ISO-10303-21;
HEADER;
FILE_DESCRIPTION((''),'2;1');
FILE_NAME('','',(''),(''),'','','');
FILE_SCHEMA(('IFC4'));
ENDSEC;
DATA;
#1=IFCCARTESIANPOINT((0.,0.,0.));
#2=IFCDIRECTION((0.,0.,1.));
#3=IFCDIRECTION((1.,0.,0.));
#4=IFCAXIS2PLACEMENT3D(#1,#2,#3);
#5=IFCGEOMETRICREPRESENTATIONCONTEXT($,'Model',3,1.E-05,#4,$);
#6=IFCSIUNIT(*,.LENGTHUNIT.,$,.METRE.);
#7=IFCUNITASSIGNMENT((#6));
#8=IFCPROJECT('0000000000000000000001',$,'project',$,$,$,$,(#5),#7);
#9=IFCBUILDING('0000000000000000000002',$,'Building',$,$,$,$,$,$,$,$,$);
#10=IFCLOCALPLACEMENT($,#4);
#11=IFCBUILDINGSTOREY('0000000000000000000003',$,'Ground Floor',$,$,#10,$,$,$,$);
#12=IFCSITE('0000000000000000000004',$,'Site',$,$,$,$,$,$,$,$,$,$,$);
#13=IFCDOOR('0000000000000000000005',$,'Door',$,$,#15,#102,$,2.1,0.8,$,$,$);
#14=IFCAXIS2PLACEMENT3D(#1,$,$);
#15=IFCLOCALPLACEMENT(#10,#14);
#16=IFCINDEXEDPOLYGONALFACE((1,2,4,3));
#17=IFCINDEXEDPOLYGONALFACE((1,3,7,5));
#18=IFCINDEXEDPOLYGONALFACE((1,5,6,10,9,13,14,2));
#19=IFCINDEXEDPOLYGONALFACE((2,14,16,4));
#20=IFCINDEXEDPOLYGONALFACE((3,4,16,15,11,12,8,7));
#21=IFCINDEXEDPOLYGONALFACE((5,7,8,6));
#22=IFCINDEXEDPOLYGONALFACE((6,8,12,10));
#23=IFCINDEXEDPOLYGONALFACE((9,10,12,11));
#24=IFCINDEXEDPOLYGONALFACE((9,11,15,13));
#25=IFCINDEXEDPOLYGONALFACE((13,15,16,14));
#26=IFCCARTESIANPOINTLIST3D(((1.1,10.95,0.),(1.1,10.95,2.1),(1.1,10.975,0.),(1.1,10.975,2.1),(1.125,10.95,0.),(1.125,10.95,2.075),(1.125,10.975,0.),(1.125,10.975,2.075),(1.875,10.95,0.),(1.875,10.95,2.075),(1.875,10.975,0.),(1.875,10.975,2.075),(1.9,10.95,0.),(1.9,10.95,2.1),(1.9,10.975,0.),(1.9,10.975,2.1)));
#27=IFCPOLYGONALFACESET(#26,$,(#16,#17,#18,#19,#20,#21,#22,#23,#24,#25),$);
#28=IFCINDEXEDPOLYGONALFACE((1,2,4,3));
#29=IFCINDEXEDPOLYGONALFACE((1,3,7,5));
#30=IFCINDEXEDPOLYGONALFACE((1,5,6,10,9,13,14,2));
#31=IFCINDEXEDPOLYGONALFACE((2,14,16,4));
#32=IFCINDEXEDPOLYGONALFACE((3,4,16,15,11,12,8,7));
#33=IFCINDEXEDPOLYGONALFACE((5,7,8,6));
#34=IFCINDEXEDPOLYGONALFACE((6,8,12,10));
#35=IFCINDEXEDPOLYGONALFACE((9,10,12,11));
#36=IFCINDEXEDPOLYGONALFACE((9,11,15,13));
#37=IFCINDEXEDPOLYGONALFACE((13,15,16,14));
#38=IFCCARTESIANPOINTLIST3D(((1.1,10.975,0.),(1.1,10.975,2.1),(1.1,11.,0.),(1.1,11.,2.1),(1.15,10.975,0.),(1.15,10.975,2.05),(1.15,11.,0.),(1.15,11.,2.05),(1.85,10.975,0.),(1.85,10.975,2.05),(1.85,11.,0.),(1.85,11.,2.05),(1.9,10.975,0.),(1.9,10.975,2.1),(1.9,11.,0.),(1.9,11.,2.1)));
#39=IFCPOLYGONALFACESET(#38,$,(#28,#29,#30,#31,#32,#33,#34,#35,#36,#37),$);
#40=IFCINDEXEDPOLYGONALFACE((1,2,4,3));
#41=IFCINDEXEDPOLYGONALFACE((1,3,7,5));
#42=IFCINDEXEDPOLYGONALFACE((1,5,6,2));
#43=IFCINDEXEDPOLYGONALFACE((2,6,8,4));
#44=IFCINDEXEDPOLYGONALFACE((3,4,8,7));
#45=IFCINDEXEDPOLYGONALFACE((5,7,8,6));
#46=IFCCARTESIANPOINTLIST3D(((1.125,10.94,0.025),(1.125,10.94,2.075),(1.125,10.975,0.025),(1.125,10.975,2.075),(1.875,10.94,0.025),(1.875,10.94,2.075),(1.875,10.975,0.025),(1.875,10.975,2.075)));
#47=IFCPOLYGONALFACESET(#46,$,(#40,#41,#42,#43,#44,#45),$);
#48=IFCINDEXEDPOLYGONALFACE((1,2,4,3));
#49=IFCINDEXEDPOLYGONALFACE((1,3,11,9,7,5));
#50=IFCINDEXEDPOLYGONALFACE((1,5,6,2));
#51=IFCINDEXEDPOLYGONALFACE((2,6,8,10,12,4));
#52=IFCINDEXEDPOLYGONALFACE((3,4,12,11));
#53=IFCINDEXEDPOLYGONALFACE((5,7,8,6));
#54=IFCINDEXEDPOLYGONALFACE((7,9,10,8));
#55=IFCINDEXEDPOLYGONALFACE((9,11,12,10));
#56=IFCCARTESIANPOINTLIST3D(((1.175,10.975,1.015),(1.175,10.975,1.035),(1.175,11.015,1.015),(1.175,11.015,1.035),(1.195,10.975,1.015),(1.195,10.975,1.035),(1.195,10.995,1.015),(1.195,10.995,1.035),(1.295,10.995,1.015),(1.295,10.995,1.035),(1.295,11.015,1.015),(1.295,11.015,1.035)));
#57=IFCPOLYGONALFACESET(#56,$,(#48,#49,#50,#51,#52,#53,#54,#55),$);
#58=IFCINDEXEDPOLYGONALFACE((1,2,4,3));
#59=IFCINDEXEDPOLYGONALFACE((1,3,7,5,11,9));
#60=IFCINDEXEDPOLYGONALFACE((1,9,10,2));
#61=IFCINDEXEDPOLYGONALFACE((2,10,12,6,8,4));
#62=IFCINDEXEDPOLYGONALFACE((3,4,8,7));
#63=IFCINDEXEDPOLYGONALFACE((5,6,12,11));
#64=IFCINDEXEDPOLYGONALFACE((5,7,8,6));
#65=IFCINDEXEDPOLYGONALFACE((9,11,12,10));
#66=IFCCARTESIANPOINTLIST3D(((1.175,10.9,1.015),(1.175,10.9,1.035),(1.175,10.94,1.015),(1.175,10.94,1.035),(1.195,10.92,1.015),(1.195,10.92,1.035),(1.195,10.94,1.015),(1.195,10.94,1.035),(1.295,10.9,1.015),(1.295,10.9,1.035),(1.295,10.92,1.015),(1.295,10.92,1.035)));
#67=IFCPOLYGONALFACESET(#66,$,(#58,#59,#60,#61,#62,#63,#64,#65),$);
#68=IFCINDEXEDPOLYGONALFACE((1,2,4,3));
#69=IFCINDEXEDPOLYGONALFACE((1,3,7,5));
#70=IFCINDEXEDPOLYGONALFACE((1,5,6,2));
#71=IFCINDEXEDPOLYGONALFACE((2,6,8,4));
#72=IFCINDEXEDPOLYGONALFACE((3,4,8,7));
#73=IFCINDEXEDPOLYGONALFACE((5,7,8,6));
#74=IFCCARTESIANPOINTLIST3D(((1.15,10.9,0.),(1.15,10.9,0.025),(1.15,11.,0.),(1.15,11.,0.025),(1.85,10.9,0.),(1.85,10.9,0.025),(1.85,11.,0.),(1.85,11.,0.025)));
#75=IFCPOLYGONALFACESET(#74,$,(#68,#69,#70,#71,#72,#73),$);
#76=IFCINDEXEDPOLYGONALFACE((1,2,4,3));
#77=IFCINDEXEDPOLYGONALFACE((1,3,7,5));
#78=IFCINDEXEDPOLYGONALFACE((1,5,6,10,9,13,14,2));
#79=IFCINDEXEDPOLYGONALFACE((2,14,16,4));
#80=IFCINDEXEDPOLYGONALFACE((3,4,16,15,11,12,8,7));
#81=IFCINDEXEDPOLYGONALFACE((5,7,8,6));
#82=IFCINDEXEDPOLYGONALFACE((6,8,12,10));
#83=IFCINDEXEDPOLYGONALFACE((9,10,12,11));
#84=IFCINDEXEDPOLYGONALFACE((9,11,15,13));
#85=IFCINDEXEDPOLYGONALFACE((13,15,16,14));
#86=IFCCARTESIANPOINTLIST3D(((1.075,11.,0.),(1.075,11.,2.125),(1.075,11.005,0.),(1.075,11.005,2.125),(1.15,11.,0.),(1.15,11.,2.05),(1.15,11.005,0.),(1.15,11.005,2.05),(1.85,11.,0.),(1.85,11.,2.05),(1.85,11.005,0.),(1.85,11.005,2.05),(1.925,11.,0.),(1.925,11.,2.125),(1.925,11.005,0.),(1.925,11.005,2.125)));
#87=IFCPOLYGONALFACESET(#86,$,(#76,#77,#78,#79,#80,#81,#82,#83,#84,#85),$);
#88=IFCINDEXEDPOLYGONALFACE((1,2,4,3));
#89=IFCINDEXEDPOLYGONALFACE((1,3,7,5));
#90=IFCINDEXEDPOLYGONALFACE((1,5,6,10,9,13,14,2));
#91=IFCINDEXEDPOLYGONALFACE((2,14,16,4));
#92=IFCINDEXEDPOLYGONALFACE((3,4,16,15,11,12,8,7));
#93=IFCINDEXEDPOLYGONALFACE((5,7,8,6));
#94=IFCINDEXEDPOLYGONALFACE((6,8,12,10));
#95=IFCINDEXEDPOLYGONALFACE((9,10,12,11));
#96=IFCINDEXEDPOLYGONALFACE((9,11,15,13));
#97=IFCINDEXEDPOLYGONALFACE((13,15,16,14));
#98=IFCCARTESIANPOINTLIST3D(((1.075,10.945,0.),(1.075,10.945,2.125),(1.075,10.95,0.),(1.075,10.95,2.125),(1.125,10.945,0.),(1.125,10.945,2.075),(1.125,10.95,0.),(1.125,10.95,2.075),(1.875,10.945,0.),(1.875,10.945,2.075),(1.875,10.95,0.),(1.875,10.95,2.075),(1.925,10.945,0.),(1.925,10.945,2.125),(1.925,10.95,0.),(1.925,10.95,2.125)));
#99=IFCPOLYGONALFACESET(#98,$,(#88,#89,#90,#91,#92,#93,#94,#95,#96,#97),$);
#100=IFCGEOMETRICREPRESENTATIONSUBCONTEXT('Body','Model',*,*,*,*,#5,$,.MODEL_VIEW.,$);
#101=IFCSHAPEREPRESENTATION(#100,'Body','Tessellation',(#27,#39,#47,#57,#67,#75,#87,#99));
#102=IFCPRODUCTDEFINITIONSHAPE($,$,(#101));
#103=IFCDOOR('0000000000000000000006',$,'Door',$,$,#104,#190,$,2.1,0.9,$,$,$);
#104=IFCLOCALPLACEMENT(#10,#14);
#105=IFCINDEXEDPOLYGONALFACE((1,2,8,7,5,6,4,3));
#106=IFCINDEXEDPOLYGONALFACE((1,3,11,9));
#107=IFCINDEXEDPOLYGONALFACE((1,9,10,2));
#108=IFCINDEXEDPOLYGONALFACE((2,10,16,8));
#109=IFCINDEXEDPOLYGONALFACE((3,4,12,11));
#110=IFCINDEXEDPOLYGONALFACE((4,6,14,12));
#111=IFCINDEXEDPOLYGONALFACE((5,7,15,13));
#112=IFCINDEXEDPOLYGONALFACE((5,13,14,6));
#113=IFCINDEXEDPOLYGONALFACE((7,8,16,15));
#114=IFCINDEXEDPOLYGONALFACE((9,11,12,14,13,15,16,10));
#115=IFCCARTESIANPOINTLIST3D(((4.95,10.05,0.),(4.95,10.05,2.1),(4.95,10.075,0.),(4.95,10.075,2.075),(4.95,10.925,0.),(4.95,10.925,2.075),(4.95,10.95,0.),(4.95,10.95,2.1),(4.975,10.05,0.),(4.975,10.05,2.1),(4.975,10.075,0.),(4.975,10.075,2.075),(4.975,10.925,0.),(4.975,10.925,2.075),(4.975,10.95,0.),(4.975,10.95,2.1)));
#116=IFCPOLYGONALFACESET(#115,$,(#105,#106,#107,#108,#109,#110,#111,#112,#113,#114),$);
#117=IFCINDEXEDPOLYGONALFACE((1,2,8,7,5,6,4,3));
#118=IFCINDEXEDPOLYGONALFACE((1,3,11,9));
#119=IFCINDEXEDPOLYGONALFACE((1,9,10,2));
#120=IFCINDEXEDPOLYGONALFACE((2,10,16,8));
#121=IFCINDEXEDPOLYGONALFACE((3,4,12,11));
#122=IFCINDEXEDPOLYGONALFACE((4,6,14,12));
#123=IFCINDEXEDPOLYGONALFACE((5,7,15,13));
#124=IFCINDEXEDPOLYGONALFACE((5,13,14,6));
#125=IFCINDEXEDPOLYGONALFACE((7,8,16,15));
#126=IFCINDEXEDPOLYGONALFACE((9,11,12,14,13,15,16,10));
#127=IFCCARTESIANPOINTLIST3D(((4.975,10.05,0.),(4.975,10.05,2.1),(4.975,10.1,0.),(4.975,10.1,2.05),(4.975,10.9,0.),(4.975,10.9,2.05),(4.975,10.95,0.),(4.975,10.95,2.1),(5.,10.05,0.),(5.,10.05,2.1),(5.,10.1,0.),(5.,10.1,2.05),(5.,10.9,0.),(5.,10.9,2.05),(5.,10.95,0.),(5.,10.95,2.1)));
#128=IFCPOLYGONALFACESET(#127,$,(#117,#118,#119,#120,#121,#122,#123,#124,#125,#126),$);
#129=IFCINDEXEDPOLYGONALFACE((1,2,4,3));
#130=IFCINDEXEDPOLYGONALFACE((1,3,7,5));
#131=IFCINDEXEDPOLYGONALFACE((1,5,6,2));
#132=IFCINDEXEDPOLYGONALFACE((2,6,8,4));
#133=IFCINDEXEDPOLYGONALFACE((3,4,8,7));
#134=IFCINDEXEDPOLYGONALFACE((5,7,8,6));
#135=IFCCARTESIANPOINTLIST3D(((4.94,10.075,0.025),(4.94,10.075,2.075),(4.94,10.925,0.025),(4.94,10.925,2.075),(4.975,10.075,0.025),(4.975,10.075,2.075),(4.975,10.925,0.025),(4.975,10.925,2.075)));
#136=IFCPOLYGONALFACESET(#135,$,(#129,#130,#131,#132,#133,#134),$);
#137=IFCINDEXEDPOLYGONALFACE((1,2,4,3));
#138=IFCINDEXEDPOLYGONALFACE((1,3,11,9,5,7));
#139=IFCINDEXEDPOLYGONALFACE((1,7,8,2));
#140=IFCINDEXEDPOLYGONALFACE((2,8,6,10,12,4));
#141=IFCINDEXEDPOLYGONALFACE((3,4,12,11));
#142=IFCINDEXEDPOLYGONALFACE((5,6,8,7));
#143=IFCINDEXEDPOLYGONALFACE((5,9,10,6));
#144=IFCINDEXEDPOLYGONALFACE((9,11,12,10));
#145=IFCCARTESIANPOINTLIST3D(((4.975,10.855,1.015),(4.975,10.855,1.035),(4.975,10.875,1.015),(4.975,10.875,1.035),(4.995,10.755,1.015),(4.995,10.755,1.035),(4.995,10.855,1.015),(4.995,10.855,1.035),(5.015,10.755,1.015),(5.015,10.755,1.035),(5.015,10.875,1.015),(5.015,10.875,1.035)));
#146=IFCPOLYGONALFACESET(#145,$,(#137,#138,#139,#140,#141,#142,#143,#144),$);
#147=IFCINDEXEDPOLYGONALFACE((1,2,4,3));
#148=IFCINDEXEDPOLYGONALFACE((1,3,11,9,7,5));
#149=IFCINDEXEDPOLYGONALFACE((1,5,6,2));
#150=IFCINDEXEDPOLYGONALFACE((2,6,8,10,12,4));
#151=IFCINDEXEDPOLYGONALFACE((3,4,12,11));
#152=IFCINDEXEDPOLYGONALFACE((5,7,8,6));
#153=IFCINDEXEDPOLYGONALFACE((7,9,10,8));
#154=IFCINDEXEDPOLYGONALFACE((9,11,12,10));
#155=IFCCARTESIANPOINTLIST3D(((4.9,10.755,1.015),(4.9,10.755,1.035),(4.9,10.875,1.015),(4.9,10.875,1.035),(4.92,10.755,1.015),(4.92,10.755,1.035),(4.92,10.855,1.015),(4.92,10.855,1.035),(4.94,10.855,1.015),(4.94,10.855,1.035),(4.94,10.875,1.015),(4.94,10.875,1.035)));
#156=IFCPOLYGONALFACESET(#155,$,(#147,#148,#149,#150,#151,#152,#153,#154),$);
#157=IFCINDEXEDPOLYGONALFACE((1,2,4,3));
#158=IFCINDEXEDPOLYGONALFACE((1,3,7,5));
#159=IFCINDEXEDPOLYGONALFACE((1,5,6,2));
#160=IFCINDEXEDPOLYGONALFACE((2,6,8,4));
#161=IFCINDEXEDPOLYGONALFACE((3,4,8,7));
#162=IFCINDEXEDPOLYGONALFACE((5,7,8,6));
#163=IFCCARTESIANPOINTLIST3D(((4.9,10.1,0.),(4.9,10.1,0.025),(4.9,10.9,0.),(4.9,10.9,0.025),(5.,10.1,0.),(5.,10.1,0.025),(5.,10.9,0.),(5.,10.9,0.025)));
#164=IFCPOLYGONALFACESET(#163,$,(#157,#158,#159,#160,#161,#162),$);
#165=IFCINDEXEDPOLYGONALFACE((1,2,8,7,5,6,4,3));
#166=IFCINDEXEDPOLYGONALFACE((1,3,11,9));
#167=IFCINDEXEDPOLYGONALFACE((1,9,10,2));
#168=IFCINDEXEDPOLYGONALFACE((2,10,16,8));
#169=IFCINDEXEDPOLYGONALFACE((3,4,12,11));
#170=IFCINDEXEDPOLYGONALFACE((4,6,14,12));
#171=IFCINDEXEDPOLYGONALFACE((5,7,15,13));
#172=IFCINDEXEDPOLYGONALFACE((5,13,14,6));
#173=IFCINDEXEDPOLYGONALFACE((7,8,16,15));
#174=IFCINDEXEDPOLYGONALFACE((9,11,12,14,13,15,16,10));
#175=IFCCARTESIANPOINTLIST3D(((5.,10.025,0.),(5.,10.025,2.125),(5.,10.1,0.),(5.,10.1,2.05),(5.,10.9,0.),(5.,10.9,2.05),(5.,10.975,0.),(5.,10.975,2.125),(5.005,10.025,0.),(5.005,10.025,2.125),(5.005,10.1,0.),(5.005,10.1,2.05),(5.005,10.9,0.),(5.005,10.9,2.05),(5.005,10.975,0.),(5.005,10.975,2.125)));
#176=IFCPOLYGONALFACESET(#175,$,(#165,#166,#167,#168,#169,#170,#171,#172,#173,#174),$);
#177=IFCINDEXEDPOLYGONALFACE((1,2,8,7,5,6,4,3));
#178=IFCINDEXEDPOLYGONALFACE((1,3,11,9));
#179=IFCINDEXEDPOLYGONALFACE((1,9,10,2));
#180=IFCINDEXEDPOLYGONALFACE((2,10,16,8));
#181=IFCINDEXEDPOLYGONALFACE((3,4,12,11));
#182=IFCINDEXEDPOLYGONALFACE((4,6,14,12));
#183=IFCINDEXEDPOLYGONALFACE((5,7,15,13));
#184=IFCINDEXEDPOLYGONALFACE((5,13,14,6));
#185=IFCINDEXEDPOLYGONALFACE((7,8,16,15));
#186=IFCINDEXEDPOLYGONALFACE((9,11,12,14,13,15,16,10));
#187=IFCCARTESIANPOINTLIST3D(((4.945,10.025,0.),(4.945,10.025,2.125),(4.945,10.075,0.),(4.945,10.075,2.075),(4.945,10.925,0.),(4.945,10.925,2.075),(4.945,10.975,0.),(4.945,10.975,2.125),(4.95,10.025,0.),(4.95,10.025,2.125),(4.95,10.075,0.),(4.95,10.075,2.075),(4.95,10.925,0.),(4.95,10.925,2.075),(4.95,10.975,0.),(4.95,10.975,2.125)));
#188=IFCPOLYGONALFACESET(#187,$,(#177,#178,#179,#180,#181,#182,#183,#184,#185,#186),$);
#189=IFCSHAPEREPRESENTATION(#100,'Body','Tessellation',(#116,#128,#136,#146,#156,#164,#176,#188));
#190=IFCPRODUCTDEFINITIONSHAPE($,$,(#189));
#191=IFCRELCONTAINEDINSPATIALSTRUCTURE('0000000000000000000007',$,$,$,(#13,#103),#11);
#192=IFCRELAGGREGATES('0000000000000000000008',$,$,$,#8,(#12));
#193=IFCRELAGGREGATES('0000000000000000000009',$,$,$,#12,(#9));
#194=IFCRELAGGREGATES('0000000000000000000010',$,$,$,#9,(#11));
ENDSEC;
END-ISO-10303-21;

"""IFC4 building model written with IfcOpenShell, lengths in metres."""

from ifc_helpers import new_model, si_unit, frame, origin_with_axes, place, context, subcontext, project, spatial, line, indexed_curve, outline, extrude, element, save


model = new_model("IFC4")

# Units and contexts
model_context = context("Model", 3, precision=1e-05, world=origin_with_axes())
body_context = subcontext(model_context, "Body", "Model", "MODEL_VIEW")
ifc_project = project(units=[si_unit("LENGTHUNIT", "METRE")], contexts=[model_context])

# Site, building, storey
site = spatial("IfcSite", under=ifc_project, Name="Site")
building = spatial("IfcBuilding", under=site, Name="Building")
storey_placement = place(None, origin_with_axes())
storey = spatial("IfcBuildingStorey", under=building, at=storey_placement, Name="Ground Floor")

# Doors
door_1_placement = place(storey_placement, frame((1.9, 11.0, 0.0), z_axis=(0.0, 0.0, 1.0), x_axis=(-1.0, 0.0, 0.0)))
element("IfcDoor", 1, at=door_1_placement, inside=storey, Name="Door", OverallHeight=2.1, OverallWidth=0.8, context=body_context, shape_type="SweptSolid", body=[
    extrude(outline(indexed_curve([(0.0, 0.0), (0.0, 2.1), (0.8, 2.1), (0.8, 0.0), (0.775, 0.0), (0.775, 2.075), (0.025, 2.075), (0.025, 0.0)], segments=[line(1, 2, 3, 4, 5, 6, 7, 8, 1)])), frame((0.0, 0.025, 0.0), z_axis=(0.0, -1.0, 0.0), x_axis=(1.0, 0.0, 0.0)), (0.0, 0.0, -1.0), 0.025),
    extrude(outline(indexed_curve([(0.0, 0.0), (0.0, 2.1), (0.8, 2.1), (0.8, 0.0), (0.75, 0.0), (0.75, 2.05), (0.05, 2.05), (0.05, 0.0)], segments=[line(1, 2, 3, 4, 5, 6, 7, 8, 1)])), frame((0.0, 0.0, 0.0), z_axis=(0.0, -1.0, 0.0), x_axis=(1.0, 0.0, 0.0)), (0.0, 0.0, -1.0), 0.025),
    extrude(outline(indexed_curve([(0.0, 0.0), (0.75, 0.0), (0.75, 0.035), (0.0, 0.035)], segments=[line(1, 2, 3, 4, 1)])), frame((0.025, 0.025, 0.025), z_axis=(0.0, 0.0, 1.0), x_axis=(1.0, 0.0, 0.0)), (0.0, 0.0, 1.0), 2.05),
    extrude(outline(indexed_curve([(0.0, 0.0), (0.0, -0.04), (-0.12, -0.04), (-0.12, -0.02), (-0.02, -0.02), (-0.02, 0.0)], segments=[line(1, 2, 3, 4, 5, 6, 1)])), frame((0.725, 0.025, 1.015), z_axis=(0.0, 0.0, 1.0), x_axis=(1.0, 0.0, 0.0)), (0.0, 0.0, 1.0), 0.02),
    extrude(outline(indexed_curve([(0.0, 0.0), (0.0, 0.04), (-0.12, 0.04), (-0.12, 0.02), (-0.02, 0.02), (-0.02, 0.0)], segments=[line(1, 2, 3, 4, 5, 6, 1)])), frame((0.725, 0.06, 1.015), z_axis=(0.0, 0.0, 1.0), x_axis=(1.0, 0.0, 0.0)), (0.0, 0.0, 1.0), 0.02),
    extrude(outline(indexed_curve([(0.0, 0.0), (0.7, 0.0), (0.7, 0.1), (0.0, 0.1)], segments=[line(1, 2, 3, 4, 1)])), frame((0.05, 0.0, 0.0), z_axis=(0.0, 0.0, 1.0), x_axis=(1.0, 0.0, 0.0)), (0.0, 0.0, 1.0), 0.025),
    extrude(outline(indexed_curve([(0.0, 0.0), (0.0, 2.125), (0.85, 2.125), (0.85, 0.0), (0.775, 0.0), (0.775, 2.05), (0.075, 2.05), (0.075, 0.0)], segments=[line(1, 2, 3, 4, 5, 6, 7, 8, 1)])), frame((-0.025, -0.005, 0.0), z_axis=(0.0, -1.0, 0.0), x_axis=(1.0, 0.0, 0.0)), (0.0, 0.0, -1.0), 0.005),
    extrude(outline(indexed_curve([(0.0, 0.0), (0.0, 2.125), (0.85, 2.125), (0.85, 0.0), (0.8, 0.0), (0.8, 2.075), (0.05, 2.075), (0.05, 0.0)], segments=[line(1, 2, 3, 4, 5, 6, 7, 8, 1)])), frame((-0.025, 0.05, 0.0), z_axis=(0.0, -1.0, 0.0), x_axis=(1.0, 0.0, 0.0)), (0.0, 0.0, -1.0), 0.005),
])
door_2_placement = place(storey_placement, frame((5.0, 10.05, 0.0), z_axis=(0.0, 0.0, 1.0), x_axis=(0.0, 1.0, 0.0)))
element("IfcDoor", 2, at=door_2_placement, inside=storey, Name="Door", OverallHeight=2.1, OverallWidth=0.9, context=body_context, shape_type="SweptSolid", body=[
    extrude(outline(indexed_curve([(0.0, 0.0), (0.0, 2.1), (0.9, 2.1), (0.9, 0.0), (0.875, 0.0), (0.875, 2.075), (0.025, 2.075), (0.025, 0.0)], segments=[line(1, 2, 3, 4, 5, 6, 7, 8, 1)])), frame((0.0, 0.025, 0.0), z_axis=(0.0, -1.0, 0.0), x_axis=(1.0, 0.0, 0.0)), (0.0, 0.0, -1.0), 0.025),
    extrude(outline(indexed_curve([(0.0, 0.0), (0.0, 2.1), (0.9, 2.1), (0.9, 0.0), (0.85, 0.0), (0.85, 2.05), (0.05, 2.05), (0.05, 0.0)], segments=[line(1, 2, 3, 4, 5, 6, 7, 8, 1)])), frame((0.0, 0.0, 0.0), z_axis=(0.0, -1.0, 0.0), x_axis=(1.0, 0.0, 0.0)), (0.0, 0.0, -1.0), 0.025),
    extrude(outline(indexed_curve([(0.0, 0.0), (0.85, 0.0), (0.85, 0.035), (0.0, 0.035)], segments=[line(1, 2, 3, 4, 1)])), frame((0.025, 0.025, 0.025), z_axis=(0.0, 0.0, 1.0), x_axis=(1.0, 0.0, 0.0)), (0.0, 0.0, 1.0), 2.05),
    extrude(outline(indexed_curve([(0.0, 0.0), (0.0, -0.04), (-0.12, -0.04), (-0.12, -0.02), (-0.02, -0.02), (-0.02, 0.0)], segments=[line(1, 2, 3, 4, 5, 6, 1)])), frame((0.825, 0.025, 1.015), z_axis=(0.0, 0.0, 1.0), x_axis=(1.0, 0.0, 0.0)), (0.0, 0.0, 1.0), 0.02),
    extrude(outline(indexed_curve([(0.0, 0.0), (0.0, 0.04), (-0.12, 0.04), (-0.12, 0.02), (-0.02, 0.02), (-0.02, 0.0)], segments=[line(1, 2, 3, 4, 5, 6, 1)])), frame((0.825, 0.06, 1.015), z_axis=(0.0, 0.0, 1.0), x_axis=(1.0, 0.0, 0.0)), (0.0, 0.0, 1.0), 0.02),
    extrude(outline(indexed_curve([(0.0, 0.0), (0.8, 0.0), (0.8, 0.1), (0.0, 0.1)], segments=[line(1, 2, 3, 4, 1)])), frame((0.05, 0.0, 0.0), z_axis=(0.0, 0.0, 1.0), x_axis=(1.0, 0.0, 0.0)), (0.0, 0.0, 1.0), 0.025),
    extrude(outline(indexed_curve([(0.0, 0.0), (0.0, 2.125), (0.95, 2.125), (0.95, 0.0), (0.875, 0.0), (0.875, 2.05), (0.075, 2.05), (0.075, 0.0)], segments=[line(1, 2, 3, 4, 5, 6, 7, 8, 1)])), frame((-0.025, -0.005, 0.0), z_axis=(0.0, -1.0, 0.0), x_axis=(1.0, 0.0, 0.0)), (0.0, 0.0, -1.0), 0.005),
    extrude(outline(indexed_curve([(0.0, 0.0), (0.0, 2.125), (0.95, 2.125), (0.95, 0.0), (0.9, 0.0), (0.9, 2.075), (0.05, 2.075), (0.05, 0.0)], segments=[line(1, 2, 3, 4, 5, 6, 7, 8, 1)])), frame((-0.025, 0.05, 0.0), z_axis=(0.0, -1.0, 0.0), x_axis=(1.0, 0.0, 0.0)), (0.0, 0.0, -1.0), 0.005),
])

save(model, "model.ifc")
